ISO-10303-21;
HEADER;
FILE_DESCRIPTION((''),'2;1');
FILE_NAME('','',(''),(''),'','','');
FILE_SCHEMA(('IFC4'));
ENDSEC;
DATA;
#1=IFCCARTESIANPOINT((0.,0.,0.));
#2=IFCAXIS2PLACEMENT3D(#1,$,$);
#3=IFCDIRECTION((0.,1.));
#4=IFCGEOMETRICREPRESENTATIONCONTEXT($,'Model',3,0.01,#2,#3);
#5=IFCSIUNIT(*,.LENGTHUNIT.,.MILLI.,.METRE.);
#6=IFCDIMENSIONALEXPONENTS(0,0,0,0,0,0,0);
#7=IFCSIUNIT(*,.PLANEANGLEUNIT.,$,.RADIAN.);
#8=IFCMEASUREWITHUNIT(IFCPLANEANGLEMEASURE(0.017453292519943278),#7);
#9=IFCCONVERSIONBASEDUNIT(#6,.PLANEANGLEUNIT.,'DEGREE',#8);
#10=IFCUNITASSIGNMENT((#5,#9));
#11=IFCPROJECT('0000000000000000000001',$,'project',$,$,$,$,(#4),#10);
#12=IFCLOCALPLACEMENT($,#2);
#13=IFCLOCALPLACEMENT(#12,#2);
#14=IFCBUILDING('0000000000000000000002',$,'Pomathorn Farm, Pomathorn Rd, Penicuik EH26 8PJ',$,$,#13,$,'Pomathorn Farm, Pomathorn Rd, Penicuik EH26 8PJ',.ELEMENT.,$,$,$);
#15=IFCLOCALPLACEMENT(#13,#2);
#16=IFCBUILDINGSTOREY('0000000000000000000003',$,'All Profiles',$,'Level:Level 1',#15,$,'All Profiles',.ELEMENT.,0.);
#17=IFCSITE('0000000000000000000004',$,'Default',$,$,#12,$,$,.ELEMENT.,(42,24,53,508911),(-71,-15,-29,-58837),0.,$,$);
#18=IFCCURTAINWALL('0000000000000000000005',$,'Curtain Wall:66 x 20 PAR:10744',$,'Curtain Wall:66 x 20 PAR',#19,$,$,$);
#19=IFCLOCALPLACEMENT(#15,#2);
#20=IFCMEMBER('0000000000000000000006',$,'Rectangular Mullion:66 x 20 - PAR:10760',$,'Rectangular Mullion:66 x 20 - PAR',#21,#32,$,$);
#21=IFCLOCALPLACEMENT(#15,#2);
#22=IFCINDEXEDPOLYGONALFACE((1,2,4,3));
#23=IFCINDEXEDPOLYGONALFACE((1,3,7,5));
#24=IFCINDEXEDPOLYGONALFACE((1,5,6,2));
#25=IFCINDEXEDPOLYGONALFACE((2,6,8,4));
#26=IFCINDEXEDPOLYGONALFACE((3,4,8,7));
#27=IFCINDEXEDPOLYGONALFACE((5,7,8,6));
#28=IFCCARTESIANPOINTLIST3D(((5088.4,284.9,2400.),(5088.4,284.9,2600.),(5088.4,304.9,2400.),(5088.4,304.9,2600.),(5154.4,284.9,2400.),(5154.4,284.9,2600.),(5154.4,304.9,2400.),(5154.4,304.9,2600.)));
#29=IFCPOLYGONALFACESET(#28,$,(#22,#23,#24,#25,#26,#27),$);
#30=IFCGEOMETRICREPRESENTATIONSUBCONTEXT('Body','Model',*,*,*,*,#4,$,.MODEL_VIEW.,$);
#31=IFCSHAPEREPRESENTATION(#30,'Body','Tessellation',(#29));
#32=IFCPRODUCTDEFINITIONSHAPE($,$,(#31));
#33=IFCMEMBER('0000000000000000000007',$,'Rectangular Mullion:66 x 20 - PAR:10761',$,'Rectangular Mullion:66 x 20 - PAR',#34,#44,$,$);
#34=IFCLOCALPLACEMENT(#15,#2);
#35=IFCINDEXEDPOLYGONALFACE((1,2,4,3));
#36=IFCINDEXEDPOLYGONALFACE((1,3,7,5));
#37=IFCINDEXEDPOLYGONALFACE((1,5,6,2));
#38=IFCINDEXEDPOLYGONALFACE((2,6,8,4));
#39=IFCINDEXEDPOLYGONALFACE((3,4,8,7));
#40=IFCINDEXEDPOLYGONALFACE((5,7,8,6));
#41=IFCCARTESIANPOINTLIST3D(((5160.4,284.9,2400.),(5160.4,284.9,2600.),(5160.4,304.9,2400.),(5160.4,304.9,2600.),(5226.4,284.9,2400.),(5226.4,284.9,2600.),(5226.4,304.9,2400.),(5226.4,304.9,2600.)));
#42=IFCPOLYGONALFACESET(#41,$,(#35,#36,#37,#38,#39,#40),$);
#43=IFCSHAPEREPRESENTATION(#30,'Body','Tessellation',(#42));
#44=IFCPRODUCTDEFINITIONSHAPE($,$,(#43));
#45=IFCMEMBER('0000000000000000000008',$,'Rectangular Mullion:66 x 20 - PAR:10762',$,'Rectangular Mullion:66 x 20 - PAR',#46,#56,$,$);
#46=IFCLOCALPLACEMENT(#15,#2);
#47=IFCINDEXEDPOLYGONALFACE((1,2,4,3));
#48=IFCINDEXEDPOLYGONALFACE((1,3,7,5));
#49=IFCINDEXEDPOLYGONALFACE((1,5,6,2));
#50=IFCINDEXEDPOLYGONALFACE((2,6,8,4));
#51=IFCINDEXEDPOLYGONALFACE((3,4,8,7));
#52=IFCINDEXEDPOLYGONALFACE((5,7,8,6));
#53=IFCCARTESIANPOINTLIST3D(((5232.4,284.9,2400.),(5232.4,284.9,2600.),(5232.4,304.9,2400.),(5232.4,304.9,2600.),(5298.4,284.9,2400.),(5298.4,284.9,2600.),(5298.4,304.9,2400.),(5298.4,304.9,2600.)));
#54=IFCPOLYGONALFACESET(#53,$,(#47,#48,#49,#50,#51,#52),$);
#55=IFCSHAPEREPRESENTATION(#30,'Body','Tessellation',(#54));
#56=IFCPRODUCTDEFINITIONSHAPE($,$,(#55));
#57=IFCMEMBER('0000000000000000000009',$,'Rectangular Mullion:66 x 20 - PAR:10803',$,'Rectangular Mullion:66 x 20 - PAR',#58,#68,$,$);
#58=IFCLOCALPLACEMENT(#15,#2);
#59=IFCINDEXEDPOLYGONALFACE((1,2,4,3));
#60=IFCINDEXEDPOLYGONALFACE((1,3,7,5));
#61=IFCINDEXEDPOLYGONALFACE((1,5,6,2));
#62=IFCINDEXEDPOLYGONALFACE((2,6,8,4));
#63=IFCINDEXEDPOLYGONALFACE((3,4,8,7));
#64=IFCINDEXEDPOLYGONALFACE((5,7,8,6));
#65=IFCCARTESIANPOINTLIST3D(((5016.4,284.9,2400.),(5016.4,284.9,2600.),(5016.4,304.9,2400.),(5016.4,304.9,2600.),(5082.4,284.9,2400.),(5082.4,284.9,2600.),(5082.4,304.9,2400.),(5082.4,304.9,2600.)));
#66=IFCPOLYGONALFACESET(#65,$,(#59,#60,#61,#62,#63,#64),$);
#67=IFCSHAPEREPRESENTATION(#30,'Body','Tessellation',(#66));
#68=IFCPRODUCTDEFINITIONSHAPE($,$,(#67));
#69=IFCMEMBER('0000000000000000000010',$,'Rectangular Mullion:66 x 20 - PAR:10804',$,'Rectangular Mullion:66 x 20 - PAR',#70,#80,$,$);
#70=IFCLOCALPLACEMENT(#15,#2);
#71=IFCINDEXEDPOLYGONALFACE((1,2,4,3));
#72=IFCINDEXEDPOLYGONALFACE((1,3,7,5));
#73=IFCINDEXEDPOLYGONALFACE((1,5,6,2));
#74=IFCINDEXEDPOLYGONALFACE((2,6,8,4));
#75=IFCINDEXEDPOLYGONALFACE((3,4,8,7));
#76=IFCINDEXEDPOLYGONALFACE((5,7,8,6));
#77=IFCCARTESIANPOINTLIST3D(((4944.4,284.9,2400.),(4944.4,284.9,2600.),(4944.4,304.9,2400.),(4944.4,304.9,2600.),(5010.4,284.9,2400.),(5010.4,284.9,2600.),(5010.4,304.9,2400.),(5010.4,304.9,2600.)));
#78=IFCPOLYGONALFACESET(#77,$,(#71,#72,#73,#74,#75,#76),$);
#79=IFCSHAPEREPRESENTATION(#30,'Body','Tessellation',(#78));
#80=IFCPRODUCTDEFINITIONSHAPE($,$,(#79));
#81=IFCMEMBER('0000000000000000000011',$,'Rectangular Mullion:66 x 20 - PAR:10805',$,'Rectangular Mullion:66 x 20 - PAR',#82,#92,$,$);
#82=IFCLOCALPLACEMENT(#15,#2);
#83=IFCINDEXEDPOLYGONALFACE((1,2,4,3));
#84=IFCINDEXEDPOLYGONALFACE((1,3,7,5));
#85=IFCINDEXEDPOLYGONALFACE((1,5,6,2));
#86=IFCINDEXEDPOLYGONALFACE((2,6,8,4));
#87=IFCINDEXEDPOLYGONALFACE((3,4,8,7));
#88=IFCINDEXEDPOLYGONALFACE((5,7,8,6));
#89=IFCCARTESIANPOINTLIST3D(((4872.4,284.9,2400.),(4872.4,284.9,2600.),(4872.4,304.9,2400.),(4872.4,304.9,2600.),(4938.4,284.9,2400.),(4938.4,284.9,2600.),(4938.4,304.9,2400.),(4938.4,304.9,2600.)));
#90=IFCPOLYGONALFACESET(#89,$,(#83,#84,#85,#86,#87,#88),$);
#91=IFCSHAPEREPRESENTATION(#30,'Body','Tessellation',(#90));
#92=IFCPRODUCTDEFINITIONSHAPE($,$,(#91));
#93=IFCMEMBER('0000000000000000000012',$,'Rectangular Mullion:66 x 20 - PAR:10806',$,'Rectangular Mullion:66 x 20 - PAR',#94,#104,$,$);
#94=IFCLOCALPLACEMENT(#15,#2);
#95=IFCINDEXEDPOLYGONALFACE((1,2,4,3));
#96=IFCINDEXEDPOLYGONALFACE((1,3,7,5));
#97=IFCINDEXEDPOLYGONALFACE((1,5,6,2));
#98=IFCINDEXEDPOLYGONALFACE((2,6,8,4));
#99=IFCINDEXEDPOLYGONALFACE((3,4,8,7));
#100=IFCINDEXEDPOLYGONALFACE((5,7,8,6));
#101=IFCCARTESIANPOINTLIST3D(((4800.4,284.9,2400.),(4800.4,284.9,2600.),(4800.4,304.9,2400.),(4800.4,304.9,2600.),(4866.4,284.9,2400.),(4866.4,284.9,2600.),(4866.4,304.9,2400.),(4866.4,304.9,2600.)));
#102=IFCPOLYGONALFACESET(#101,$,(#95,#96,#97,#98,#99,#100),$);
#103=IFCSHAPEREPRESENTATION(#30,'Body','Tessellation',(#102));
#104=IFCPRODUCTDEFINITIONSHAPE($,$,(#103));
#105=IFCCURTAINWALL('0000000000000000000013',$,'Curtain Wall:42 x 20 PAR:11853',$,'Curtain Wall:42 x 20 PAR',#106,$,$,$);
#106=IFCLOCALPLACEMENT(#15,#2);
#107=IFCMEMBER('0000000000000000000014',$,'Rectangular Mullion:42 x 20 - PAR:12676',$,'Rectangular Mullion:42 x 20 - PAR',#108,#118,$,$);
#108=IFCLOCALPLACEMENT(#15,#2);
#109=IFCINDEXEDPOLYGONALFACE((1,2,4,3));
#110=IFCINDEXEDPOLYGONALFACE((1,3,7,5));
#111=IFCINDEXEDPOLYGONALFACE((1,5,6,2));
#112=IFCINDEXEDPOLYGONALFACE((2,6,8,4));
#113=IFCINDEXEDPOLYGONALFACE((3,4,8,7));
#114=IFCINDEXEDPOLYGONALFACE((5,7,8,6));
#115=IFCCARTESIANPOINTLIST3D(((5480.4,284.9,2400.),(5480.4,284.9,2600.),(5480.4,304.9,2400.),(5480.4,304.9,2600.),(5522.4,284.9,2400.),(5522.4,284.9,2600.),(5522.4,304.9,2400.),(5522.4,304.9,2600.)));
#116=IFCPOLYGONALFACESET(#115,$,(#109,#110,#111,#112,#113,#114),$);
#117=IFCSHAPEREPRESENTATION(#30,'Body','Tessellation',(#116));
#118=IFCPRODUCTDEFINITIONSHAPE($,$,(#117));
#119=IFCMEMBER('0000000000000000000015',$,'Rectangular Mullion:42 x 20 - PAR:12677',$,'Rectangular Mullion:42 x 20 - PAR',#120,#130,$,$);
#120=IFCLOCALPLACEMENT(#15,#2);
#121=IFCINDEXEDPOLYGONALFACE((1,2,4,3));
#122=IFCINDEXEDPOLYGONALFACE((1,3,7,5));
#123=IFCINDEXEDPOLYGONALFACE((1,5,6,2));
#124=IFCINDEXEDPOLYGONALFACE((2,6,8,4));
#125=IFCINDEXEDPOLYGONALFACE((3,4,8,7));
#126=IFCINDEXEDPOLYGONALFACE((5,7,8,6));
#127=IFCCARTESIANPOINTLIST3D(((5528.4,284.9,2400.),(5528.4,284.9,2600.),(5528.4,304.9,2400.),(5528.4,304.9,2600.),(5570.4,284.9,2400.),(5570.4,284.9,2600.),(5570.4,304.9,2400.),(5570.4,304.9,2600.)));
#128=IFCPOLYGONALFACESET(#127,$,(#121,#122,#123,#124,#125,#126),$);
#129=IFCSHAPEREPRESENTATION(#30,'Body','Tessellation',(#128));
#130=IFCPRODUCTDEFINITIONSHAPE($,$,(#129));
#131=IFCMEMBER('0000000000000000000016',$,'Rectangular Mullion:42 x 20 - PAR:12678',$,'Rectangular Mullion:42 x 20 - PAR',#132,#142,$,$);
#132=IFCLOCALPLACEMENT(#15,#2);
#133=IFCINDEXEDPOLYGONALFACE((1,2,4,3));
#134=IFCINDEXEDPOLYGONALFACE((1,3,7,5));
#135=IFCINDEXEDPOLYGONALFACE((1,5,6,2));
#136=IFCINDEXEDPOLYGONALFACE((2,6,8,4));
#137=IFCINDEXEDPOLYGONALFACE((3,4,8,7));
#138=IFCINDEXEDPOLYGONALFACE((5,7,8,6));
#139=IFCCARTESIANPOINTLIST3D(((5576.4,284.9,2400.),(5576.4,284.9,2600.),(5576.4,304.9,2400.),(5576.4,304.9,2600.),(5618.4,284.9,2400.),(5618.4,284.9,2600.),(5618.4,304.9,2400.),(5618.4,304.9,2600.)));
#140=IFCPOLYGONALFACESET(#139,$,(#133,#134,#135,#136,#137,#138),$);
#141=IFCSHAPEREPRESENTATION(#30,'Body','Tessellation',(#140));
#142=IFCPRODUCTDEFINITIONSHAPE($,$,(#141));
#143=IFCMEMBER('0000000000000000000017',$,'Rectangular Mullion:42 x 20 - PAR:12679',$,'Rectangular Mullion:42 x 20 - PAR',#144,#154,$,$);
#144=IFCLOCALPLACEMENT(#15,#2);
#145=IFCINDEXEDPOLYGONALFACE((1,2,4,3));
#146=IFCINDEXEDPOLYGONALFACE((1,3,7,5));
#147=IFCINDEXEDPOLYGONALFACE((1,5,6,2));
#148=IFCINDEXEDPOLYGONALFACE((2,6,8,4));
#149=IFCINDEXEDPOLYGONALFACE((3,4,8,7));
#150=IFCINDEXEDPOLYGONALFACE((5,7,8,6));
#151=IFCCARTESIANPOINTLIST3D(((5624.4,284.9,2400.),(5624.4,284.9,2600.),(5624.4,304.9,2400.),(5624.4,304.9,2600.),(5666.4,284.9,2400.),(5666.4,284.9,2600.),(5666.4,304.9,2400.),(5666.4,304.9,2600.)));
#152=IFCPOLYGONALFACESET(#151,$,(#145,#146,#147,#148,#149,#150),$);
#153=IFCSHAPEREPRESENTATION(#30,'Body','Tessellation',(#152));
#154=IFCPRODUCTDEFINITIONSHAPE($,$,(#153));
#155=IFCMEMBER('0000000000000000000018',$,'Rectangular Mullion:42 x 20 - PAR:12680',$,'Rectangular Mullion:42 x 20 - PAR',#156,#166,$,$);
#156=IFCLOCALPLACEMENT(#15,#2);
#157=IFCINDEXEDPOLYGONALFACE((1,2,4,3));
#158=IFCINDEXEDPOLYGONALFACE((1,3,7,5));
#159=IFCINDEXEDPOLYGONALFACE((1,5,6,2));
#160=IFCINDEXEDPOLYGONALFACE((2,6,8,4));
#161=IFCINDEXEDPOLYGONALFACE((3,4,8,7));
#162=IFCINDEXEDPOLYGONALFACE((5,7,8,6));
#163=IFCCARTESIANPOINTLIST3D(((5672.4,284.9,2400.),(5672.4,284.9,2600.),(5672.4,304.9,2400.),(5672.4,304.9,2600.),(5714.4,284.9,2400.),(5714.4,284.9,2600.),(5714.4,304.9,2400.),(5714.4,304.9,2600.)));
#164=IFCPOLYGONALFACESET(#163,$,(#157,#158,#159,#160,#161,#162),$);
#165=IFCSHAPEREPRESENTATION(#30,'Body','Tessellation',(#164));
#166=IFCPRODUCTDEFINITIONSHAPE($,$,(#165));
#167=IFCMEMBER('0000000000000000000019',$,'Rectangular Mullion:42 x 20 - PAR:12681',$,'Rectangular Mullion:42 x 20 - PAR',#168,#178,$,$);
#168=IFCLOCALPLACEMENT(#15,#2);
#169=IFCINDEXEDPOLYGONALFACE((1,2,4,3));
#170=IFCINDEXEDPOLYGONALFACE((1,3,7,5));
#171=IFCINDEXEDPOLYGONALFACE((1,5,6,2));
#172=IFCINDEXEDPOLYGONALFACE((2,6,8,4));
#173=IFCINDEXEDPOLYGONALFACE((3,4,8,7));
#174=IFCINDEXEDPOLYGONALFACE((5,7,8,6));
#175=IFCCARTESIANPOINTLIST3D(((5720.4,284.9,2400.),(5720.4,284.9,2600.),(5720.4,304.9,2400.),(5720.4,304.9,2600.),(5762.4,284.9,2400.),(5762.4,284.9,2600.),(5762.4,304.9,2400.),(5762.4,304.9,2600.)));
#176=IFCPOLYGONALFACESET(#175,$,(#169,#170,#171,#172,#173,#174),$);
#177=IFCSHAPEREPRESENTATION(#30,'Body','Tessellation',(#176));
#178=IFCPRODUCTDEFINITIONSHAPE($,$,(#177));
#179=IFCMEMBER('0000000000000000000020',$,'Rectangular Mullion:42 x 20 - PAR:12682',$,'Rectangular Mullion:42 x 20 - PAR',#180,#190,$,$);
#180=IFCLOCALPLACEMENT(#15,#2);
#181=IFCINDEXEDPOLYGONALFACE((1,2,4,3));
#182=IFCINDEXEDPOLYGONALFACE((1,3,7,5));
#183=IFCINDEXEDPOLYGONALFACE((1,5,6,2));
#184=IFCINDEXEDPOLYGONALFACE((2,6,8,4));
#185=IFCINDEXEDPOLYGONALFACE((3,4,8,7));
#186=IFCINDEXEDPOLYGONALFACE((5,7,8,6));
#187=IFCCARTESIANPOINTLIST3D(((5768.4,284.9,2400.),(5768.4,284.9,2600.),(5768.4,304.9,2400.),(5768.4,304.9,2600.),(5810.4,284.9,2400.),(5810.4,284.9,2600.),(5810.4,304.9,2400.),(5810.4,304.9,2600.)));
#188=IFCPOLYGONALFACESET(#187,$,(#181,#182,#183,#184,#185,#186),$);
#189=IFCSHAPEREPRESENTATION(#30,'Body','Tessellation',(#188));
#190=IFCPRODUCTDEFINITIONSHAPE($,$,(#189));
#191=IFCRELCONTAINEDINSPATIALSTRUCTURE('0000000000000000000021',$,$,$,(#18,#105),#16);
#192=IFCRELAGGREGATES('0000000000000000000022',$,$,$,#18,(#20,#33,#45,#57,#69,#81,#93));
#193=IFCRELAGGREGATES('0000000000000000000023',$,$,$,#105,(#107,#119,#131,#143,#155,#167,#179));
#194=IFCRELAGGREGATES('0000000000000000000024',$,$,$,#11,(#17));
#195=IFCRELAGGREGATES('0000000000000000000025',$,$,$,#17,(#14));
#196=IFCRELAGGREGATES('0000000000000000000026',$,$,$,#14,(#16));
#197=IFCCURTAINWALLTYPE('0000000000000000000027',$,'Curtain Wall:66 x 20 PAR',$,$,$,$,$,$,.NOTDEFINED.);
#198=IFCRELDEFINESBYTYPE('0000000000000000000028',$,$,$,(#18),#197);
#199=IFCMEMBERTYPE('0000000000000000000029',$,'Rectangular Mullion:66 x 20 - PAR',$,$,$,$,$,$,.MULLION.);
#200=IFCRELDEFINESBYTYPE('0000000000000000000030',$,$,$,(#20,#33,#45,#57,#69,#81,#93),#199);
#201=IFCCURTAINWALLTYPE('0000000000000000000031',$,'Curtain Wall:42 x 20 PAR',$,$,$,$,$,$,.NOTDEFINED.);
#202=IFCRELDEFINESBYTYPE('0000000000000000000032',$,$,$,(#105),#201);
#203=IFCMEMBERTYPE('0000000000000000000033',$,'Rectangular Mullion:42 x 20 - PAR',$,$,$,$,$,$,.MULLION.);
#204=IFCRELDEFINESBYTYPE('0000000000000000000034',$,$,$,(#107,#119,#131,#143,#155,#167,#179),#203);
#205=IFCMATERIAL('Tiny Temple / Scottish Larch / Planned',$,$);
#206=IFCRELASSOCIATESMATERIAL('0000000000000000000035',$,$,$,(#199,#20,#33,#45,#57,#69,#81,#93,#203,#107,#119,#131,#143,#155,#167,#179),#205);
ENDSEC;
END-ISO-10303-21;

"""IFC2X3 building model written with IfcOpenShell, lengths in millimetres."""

from ifc_helpers import new_model, entity, si_unit, converted_unit, direction, frame, frame_2d, origin, place, context, subcontext, project, spatial, rectangle, extrude, source, transform, mapped, material, type_object, type_shapes, element, aggregate, save


model = new_model("IFC2X3")

# Units and contexts
model_context = context("Model", 3, precision=0.01, world=origin(), true_north=direction((0.0, 1.0)))
body_context = subcontext(model_context, "Body", "Model", "MODEL_VIEW")
ifc_project = project(units=[si_unit("LENGTHUNIT", "METRE", prefix="MILLI"), converted_unit("PLANEANGLEUNIT", "DEGREE", entity("IfcPlaneAngleMeasure", 0.017453292519943278), si_unit("PLANEANGLEUNIT", "RADIAN"), dimensions=[0, 0, 0, 0, 0, 0, 0])], contexts=[model_context])

# Site, building, storey
site_placement = place(None, origin())
site = spatial("IfcSite", under=ifc_project, at=site_placement, Name="Default", CompositionType="ELEMENT", RefLatitude=(42, 24, 53, 508911), RefLongitude=(-71, -15, -29, -58837), RefElevation=0.0)
building_placement = place(site_placement, origin())
building = spatial("IfcBuilding", under=site, at=building_placement, Name="Pomathorn Farm, Pomathorn Rd, Penicuik EH26 8PJ", LongName="Pomathorn Farm, Pomathorn Rd, Penicuik EH26 8PJ", CompositionType="ELEMENT")
storey_placement = place(building_placement, origin())
storey = spatial("IfcBuildingStorey", under=building, at=storey_placement, Name="All Profiles", ObjectType="Level:Level 1", LongName="All Profiles", CompositionType="ELEMENT", Elevation=0.0)

# Curtain walls, members
curtain_wall_type_1 = type_object("IfcCurtainWallType", Name="Curtain Wall:66 x 20 PAR", PredefinedType="NOTDEFINED")
curtain_wall_1_placement = place(storey_placement, origin())
curtain_wall_1 = element("IfcCurtainWall", 1, at=curtain_wall_1_placement, inside=storey, type_object=curtain_wall_type_1, Name="Curtain Wall:66 x 20 PAR:10744", ObjectType="Curtain Wall:66 x 20 PAR")
ifc_material = material(Name="Tiny Temple / Scottish Larch / Planned")
member_type_1 = type_object("IfcMemberType", Name="Rectangular Mullion:66 x 20 - PAR", PredefinedType="MULLION", material=ifc_material)
shared_shape_1 = source(origin(), body_context, "Body", "SweptSolid", [
    extrude(rectangle(XDim=20.0, YDim=66.0, at=frame_2d((0.0, 0.0), x_axis=(1.0, 0.0))), frame((-33.0, -10.0, -200.0), z_axis=(0.0, 0.0, 1.0), x_axis=(0.0, 1.0, 0.0)), (0.0, 0.0, 1.0), 200.0),
])
type_shapes(member_type_1, [shared_shape_1])
member_1_placement = place(curtain_wall_1_placement, frame((5154.4, 284.9, 2400.0), z_axis=(0.0, 0.0, -1.0), x_axis=(1.0, 0.0, 0.0)))
member_1 = element("IfcMember", 2, at=member_1_placement, type_object=member_type_1, material=ifc_material, Name="Rectangular Mullion:66 x 20 - PAR:10760", ObjectType="Rectangular Mullion:66 x 20 - PAR", context=body_context, shape_type="MappedRepresentation", body=[
    mapped(shared_shape_1, transform((0.0, 0.0, 0.0), scale=1.0)),
])
member_2_placement = place(curtain_wall_1_placement, frame((5226.4, 284.9, 2400.0), z_axis=(0.0, 0.0, -1.0), x_axis=(1.0, 0.0, 0.0)))
member_2 = element("IfcMember", 3, at=member_2_placement, type_object=member_type_1, material=ifc_material, Name="Rectangular Mullion:66 x 20 - PAR:10761", ObjectType="Rectangular Mullion:66 x 20 - PAR", context=body_context, shape_type="MappedRepresentation", body=[
    mapped(shared_shape_1, transform((0.0, 0.0, 0.0), scale=1.0)),
])
member_3_placement = place(curtain_wall_1_placement, frame((5298.4, 284.9, 2400.0), z_axis=(0.0, 0.0, -1.0), x_axis=(1.0, 0.0, 0.0)))
member_3 = element("IfcMember", 4, at=member_3_placement, type_object=member_type_1, material=ifc_material, Name="Rectangular Mullion:66 x 20 - PAR:10762", ObjectType="Rectangular Mullion:66 x 20 - PAR", context=body_context, shape_type="MappedRepresentation", body=[
    mapped(shared_shape_1, transform((0.0, 0.0, 0.0), scale=1.0)),
])
member_4_placement = place(curtain_wall_1_placement, frame((5082.4, 284.9, 2400.0), z_axis=(0.0, 0.0, -1.0), x_axis=(1.0, 0.0, 0.0)))
member_4 = element("IfcMember", 5, at=member_4_placement, type_object=member_type_1, material=ifc_material, Name="Rectangular Mullion:66 x 20 - PAR:10803", ObjectType="Rectangular Mullion:66 x 20 - PAR", context=body_context, shape_type="MappedRepresentation", body=[
    mapped(shared_shape_1, transform((0.0, 0.0, 0.0), scale=1.0)),
])
member_5_placement = place(curtain_wall_1_placement, frame((5010.4, 284.9, 2400.0), z_axis=(0.0, 0.0, -1.0), x_axis=(1.0, 0.0, 0.0)))
member_5 = element("IfcMember", 6, at=member_5_placement, type_object=member_type_1, material=ifc_material, Name="Rectangular Mullion:66 x 20 - PAR:10804", ObjectType="Rectangular Mullion:66 x 20 - PAR", context=body_context, shape_type="MappedRepresentation", body=[
    mapped(shared_shape_1, transform((0.0, 0.0, 0.0), scale=1.0)),
])
member_6_placement = place(curtain_wall_1_placement, frame((4938.4, 284.9, 2400.0), z_axis=(0.0, 0.0, -1.0), x_axis=(1.0, 0.0, 0.0)))
member_6 = element("IfcMember", 7, at=member_6_placement, type_object=member_type_1, material=ifc_material, Name="Rectangular Mullion:66 x 20 - PAR:10805", ObjectType="Rectangular Mullion:66 x 20 - PAR", context=body_context, shape_type="MappedRepresentation", body=[
    mapped(shared_shape_1, transform((0.0, 0.0, 0.0), scale=1.0)),
])
member_7_placement = place(curtain_wall_1_placement, frame((4866.4, 284.9, 2400.0), z_axis=(0.0, 0.0, -1.0), x_axis=(1.0, 0.0, 0.0)))
member_7 = element("IfcMember", 8, at=member_7_placement, type_object=member_type_1, material=ifc_material, Name="Rectangular Mullion:66 x 20 - PAR:10806", ObjectType="Rectangular Mullion:66 x 20 - PAR", context=body_context, shape_type="MappedRepresentation", body=[
    mapped(shared_shape_1, transform((0.0, 0.0, 0.0), scale=1.0)),
])
aggregate(curtain_wall_1, [member_1, member_2, member_3, member_4, member_5, member_6, member_7])
curtain_wall_type_2 = type_object("IfcCurtainWallType", Name="Curtain Wall:42 x 20 PAR", PredefinedType="NOTDEFINED")
curtain_wall_2_placement = place(storey_placement, origin())
curtain_wall_2 = element("IfcCurtainWall", 9, at=curtain_wall_2_placement, inside=storey, type_object=curtain_wall_type_2, Name="Curtain Wall:42 x 20 PAR:11853", ObjectType="Curtain Wall:42 x 20 PAR")
member_type_2 = type_object("IfcMemberType", Name="Rectangular Mullion:42 x 20 - PAR", PredefinedType="MULLION", material=ifc_material)
shared_shape_2 = source(origin(), body_context, "Body", "SweptSolid", [
    extrude(rectangle(XDim=20.0, YDim=42.0, at=frame_2d((0.0, 0.0), x_axis=(1.0, 0.0))), frame((-21.0, -10.0, -200.0), z_axis=(0.0, 0.0, 1.0), x_axis=(0.0, 1.0, 0.0)), (0.0, 0.0, 1.0), 200.0),
])
type_shapes(member_type_2, [shared_shape_2])
member_8_placement = place(curtain_wall_2_placement, frame((5522.4, 284.9, 2400.0), z_axis=(0.0, 0.0, -1.0), x_axis=(1.0, 0.0, 0.0)))
member_8 = element("IfcMember", 10, at=member_8_placement, type_object=member_type_2, material=ifc_material, Name="Rectangular Mullion:42 x 20 - PAR:12676", ObjectType="Rectangular Mullion:42 x 20 - PAR", context=body_context, shape_type="MappedRepresentation", body=[
    mapped(shared_shape_2, transform((0.0, 0.0, 0.0), scale=1.0)),
])
member_9_placement = place(curtain_wall_2_placement, frame((5570.4, 284.9, 2400.0), z_axis=(0.0, 0.0, -1.0), x_axis=(1.0, 0.0, 0.0)))
member_9 = element("IfcMember", 11, at=member_9_placement, type_object=member_type_2, material=ifc_material, Name="Rectangular Mullion:42 x 20 - PAR:12677", ObjectType="Rectangular Mullion:42 x 20 - PAR", context=body_context, shape_type="MappedRepresentation", body=[
    mapped(shared_shape_2, transform((0.0, 0.0, 0.0), scale=1.0)),
])
member_10_placement = place(curtain_wall_2_placement, frame((5618.4, 284.9, 2400.0), z_axis=(0.0, 0.0, -1.0), x_axis=(1.0, 0.0, 0.0)))
member_10 = element("IfcMember", 12, at=member_10_placement, type_object=member_type_2, material=ifc_material, Name="Rectangular Mullion:42 x 20 - PAR:12678", ObjectType="Rectangular Mullion:42 x 20 - PAR", context=body_context, shape_type="MappedRepresentation", body=[
    mapped(shared_shape_2, transform((0.0, 0.0, 0.0), scale=1.0)),
])
member_11_placement = place(curtain_wall_2_placement, frame((5666.4, 284.9, 2400.0), z_axis=(0.0, 0.0, -1.0), x_axis=(1.0, 0.0, 0.0)))
member_11 = element("IfcMember", 13, at=member_11_placement, type_object=member_type_2, material=ifc_material, Name="Rectangular Mullion:42 x 20 - PAR:12679", ObjectType="Rectangular Mullion:42 x 20 - PAR", context=body_context, shape_type="MappedRepresentation", body=[
    mapped(shared_shape_2, transform((0.0, 0.0, 0.0), scale=1.0)),
])
member_12_placement = place(curtain_wall_2_placement, frame((5714.4, 284.9, 2400.0), z_axis=(0.0, 0.0, -1.0), x_axis=(1.0, 0.0, 0.0)))
member_12 = element("IfcMember", 14, at=member_12_placement, type_object=member_type_2, material=ifc_material, Name="Rectangular Mullion:42 x 20 - PAR:12680", ObjectType="Rectangular Mullion:42 x 20 - PAR", context=body_context, shape_type="MappedRepresentation", body=[
    mapped(shared_shape_2, transform((0.0, 0.0, 0.0), scale=1.0)),
])
member_13_placement = place(curtain_wall_2_placement, frame((5762.4, 284.9, 2400.0), z_axis=(0.0, 0.0, -1.0), x_axis=(1.0, 0.0, 0.0)))
member_13 = element("IfcMember", 15, at=member_13_placement, type_object=member_type_2, material=ifc_material, Name="Rectangular Mullion:42 x 20 - PAR:12681", ObjectType="Rectangular Mullion:42 x 20 - PAR", context=body_context, shape_type="MappedRepresentation", body=[
    mapped(shared_shape_2, transform((0.0, 0.0, 0.0), scale=1.0)),
])
member_14_placement = place(curtain_wall_2_placement, frame((5810.4, 284.9, 2400.0), z_axis=(0.0, 0.0, -1.0), x_axis=(1.0, 0.0, 0.0)))
member_14 = element("IfcMember", 16, at=member_14_placement, type_object=member_type_2, material=ifc_material, Name="Rectangular Mullion:42 x 20 - PAR:12682", ObjectType="Rectangular Mullion:42 x 20 - PAR", context=body_context, shape_type="MappedRepresentation", body=[
    mapped(shared_shape_2, transform((0.0, 0.0, 0.0), scale=1.0)),
])
aggregate(curtain_wall_2, [member_8, member_9, member_10, member_11, member_12, member_13, member_14])

save(model, "model.ifc")
